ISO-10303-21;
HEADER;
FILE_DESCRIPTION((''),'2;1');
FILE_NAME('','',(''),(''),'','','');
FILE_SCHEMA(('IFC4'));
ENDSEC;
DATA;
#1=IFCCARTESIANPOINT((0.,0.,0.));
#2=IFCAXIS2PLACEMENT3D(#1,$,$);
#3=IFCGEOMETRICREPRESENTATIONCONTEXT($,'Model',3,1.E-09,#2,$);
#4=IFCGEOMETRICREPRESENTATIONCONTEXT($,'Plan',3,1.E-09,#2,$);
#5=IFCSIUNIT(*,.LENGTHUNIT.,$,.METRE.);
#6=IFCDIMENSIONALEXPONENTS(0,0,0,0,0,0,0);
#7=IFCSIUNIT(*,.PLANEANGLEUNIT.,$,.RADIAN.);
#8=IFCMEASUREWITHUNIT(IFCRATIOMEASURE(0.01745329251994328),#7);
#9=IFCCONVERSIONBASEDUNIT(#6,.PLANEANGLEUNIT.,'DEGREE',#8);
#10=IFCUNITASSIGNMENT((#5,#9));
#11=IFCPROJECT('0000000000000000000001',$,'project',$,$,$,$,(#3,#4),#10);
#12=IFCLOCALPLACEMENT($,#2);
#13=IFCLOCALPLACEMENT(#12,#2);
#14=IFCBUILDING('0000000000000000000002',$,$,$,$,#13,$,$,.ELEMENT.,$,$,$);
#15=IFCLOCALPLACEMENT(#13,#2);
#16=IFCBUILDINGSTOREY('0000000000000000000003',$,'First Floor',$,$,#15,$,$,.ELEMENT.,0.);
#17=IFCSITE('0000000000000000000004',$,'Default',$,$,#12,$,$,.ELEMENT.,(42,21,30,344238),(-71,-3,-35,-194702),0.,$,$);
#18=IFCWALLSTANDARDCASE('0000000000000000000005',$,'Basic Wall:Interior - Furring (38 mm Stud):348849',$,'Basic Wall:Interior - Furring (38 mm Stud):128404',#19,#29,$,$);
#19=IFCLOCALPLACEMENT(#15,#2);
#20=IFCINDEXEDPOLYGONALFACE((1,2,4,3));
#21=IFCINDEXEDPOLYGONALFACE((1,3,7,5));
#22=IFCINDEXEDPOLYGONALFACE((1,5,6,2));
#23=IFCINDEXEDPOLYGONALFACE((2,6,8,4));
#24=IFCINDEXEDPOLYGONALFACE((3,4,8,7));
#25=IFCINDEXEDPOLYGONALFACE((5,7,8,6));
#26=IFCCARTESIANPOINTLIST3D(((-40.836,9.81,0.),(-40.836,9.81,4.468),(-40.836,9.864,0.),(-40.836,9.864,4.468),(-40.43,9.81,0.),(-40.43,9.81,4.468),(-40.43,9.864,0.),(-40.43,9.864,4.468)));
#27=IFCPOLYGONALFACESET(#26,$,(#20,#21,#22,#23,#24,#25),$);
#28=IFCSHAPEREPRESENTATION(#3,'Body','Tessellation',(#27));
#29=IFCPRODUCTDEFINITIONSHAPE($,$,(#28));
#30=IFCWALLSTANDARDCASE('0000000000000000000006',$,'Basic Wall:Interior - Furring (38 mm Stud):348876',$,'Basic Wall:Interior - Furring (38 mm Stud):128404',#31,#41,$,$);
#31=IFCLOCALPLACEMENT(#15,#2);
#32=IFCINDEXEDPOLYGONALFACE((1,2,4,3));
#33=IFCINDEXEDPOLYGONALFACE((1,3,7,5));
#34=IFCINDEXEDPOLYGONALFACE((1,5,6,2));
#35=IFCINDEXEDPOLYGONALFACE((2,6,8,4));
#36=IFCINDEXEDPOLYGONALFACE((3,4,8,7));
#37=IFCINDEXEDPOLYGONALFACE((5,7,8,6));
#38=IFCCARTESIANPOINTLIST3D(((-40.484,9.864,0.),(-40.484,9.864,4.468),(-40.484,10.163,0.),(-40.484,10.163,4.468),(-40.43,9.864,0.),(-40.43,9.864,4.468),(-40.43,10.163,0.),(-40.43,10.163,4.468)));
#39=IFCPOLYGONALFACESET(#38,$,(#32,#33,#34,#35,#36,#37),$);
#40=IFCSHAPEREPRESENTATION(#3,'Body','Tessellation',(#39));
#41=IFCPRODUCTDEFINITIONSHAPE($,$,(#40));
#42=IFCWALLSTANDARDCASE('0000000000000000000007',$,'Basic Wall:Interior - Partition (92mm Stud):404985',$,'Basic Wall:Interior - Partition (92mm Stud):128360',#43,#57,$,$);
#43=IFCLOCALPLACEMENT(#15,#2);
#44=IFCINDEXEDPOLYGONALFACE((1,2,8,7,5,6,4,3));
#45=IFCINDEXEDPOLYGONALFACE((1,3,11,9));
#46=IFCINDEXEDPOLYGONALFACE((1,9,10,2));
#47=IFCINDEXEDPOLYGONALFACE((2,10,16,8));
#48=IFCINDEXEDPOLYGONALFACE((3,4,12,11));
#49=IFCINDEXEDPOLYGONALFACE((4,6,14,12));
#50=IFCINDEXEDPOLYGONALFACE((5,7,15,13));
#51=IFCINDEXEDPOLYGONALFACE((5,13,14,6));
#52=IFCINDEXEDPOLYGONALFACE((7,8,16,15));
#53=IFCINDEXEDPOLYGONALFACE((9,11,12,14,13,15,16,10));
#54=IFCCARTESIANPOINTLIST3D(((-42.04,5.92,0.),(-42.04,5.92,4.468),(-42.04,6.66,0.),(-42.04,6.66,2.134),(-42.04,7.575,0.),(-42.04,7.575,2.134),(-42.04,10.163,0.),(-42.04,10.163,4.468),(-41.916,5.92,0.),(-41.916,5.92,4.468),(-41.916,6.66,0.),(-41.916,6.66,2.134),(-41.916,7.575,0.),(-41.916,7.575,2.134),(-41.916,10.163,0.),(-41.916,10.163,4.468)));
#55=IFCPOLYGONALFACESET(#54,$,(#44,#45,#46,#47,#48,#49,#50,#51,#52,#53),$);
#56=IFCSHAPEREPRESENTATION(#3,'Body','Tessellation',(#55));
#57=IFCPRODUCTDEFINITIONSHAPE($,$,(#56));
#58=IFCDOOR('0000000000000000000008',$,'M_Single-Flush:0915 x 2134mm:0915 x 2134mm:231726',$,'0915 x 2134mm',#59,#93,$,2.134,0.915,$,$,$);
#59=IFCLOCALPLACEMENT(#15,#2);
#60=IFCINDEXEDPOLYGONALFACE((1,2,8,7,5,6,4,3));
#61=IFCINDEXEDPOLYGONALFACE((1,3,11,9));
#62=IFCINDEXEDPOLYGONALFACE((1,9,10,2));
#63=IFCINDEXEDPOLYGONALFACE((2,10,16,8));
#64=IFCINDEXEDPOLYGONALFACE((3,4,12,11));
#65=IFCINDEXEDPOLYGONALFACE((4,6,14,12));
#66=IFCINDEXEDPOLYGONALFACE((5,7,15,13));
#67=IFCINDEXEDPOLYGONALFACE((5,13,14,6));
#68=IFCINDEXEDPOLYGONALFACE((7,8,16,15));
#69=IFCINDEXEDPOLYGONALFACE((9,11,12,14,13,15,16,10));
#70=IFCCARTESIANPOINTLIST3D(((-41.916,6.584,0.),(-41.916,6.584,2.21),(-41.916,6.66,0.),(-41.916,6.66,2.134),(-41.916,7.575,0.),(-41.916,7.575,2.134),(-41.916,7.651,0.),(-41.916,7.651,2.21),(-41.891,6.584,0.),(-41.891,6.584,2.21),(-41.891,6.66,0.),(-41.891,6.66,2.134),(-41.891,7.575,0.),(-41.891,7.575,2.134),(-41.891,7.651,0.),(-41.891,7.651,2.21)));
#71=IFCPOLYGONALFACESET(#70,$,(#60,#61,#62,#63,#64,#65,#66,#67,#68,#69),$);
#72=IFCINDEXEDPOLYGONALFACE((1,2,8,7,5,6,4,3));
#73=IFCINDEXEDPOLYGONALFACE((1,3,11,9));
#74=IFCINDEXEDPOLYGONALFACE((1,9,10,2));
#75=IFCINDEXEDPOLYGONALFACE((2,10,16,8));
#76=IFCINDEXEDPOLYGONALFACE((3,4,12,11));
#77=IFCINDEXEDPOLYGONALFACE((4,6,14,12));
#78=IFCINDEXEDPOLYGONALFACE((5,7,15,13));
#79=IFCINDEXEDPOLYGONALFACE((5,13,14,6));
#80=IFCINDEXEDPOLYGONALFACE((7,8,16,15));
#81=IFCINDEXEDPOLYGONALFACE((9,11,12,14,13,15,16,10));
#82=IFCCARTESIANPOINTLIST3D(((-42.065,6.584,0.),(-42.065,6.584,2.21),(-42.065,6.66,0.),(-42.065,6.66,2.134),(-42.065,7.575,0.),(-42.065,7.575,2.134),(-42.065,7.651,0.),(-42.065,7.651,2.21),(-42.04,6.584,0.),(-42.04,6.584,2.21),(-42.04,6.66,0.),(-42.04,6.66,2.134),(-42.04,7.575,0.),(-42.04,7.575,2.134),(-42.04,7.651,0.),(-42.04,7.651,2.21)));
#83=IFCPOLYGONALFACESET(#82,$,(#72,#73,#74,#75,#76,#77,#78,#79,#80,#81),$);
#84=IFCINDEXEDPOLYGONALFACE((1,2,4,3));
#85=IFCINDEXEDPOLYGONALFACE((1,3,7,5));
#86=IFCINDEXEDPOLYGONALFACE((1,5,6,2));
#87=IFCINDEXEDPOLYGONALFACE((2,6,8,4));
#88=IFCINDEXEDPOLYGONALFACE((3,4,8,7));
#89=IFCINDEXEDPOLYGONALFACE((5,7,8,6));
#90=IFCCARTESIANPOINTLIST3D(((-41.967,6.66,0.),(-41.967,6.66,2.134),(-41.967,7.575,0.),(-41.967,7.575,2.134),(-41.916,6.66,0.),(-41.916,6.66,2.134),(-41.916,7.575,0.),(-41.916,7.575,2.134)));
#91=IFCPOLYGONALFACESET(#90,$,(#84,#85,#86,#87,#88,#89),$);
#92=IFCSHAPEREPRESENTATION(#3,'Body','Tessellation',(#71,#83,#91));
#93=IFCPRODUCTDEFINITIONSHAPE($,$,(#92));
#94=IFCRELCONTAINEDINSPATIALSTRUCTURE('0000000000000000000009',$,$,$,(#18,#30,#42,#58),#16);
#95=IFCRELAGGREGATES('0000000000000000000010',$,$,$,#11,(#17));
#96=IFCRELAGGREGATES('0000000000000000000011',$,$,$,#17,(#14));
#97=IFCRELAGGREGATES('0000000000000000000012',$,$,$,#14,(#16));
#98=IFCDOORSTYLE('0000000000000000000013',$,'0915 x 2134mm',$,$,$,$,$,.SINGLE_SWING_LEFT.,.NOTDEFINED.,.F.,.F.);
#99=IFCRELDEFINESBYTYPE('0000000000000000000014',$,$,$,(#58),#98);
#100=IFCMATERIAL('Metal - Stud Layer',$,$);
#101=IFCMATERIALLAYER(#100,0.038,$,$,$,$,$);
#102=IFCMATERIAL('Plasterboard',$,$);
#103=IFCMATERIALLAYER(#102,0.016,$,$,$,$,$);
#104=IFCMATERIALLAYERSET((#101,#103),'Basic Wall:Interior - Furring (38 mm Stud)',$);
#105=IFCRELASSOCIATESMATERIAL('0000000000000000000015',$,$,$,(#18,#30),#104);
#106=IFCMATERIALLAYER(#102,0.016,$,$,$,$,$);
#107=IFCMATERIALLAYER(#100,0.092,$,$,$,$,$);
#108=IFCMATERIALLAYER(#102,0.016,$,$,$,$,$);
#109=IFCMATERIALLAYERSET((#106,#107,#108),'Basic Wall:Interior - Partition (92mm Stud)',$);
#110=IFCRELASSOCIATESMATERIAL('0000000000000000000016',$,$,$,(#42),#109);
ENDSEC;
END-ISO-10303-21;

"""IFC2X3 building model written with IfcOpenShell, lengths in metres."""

from ifc_helpers import new_model, entity, si_unit, converted_unit, frame, frame_2d, origin, origin_2d_with_axis, place, context, project, spatial, polyline, rectangle, outline, extrude, source, transform, mapped, material, layer, layer_set, layer_usage, type_object, type_shapes, element, fill, save


model = new_model("IFC2X3")

# Units and contexts
model_context = context("Model", 3, precision=1e-09, world=origin())
plan_context = context("Plan", 3, precision=1e-09, world=origin())
ifc_project = project(units=[si_unit("LENGTHUNIT", "METRE"), converted_unit("PLANEANGLEUNIT", "DEGREE", entity("IfcRatioMeasure", 0.01745329251994328), si_unit("PLANEANGLEUNIT", "RADIAN"), dimensions=[0, 0, 0, 0, 0, 0, 0])], contexts=[model_context, plan_context])

# Site, building, storey
site_placement = place(None, origin())
site = spatial("IfcSite", under=ifc_project, at=site_placement, Name="Default", CompositionType="ELEMENT", RefLatitude=(42, 21, 30, 344238), RefLongitude=(-71, -3, -35, -194702), RefElevation=0.0)
building_placement = place(site_placement, origin())
building = spatial("IfcBuilding", under=site, at=building_placement, CompositionType="ELEMENT")
storey_placement = place(building_placement, origin())
storey = spatial("IfcBuildingStorey", under=building, at=storey_placement, Name="First Floor", CompositionType="ELEMENT", Elevation=0.0)

# Shared definitions
ifc_material_1 = material(Name="Metal - Stud Layer")
ifc_layer_1 = layer(ifc_material_1, 0.038)
ifc_material_2 = material(Name="Plasterboard")
ifc_layer_2 = layer(ifc_material_2, 0.016)
ifc_layer_set_1 = layer_set([ifc_layer_1, ifc_layer_2], Name="Basic Wall:Interior - Furring (38 mm Stud)")

# Shared definitions
ifc_layer_3 = layer(ifc_material_2, 0.016)
ifc_layer_4 = layer(ifc_material_1, 0.092)
ifc_layer_5 = layer(ifc_material_2, 0.016)
ifc_layer_set_2 = layer_set([ifc_layer_3, ifc_layer_4, ifc_layer_5], Name="Basic Wall:Interior - Partition (92mm Stud)")
door_style_1 = type_object("IfcDoorStyle", Name="0915 x 2134mm", ConstructionType="NOTDEFINED", OperationType="SINGLE_SWING_LEFT", ParameterTakesPrecedence=False, Sizeable=False)
shared_shape_1 = source(origin(), model_context, "Body", "SweptSolid", [
    extrude(outline(polyline([(-0.5335, -1.124), (0.5335, -1.124), (0.5335, 1.086), (0.4575, 1.086), (0.4575, -1.048), (-0.4575, -1.048), (-0.4575, 1.086), (-0.5335, 1.086), (-0.5335, -1.124)])), frame((0.4575, 0.149, 1.086), z_axis=(0.0, -1.0, 0.0), x_axis=(-1.0, 0.0, 0.0)), (0.0, 0.0, 1.0), 0.025),
    extrude(outline(polyline([(-1.124, -0.5335), (1.086, -0.5335), (1.086, -0.4575), (-1.048, -0.4575), (-1.048, 0.4575), (1.086, 0.4575), (1.086, 0.5335), (-1.124, 0.5335), (-1.124, -0.5335)])), frame((0.4575, 0.0, 1.086), z_axis=(0.0, -1.0, 0.0), x_axis=(0.0, 0.0, -1.0)), (0.0, 0.0, 1.0), 0.025),
    extrude(rectangle(XDim=0.915, YDim=0.051, at=origin_2d_with_axis()), frame((0.4575, 0.0985, 0.0)), (0.0, 0.0, 1.0), 2.134),
])
type_shapes(door_style_1, [shared_shape_1])

# Walls
ifc_layer_usage_1 = layer_usage(ifc_layer_set_1, "AXIS2", "NEGATIVE", 0.027)
wall_1_placement = place(storey_placement, frame((-40.836, 9.837, 0.0)))
element("IfcWallStandardCase", 1, at=wall_1_placement, inside=storey, material=ifc_layer_usage_1, Name="Basic Wall:Interior - Furring (38 mm Stud):348849", ObjectType="Basic Wall:Interior - Furring (38 mm Stud):128404", context=model_context, shape_type="SweptSolid", body=[
    extrude(rectangle(XDim=0.406, YDim=0.054, at=frame_2d((0.203, 0.0), x_axis=(-1.0, 0.0))), origin(), (0.0, 0.0, 1.0), 4.468),
])
ifc_layer_usage_2 = layer_usage(ifc_layer_set_1, "AXIS2", "NEGATIVE", 0.027)
wall_2_placement = place(storey_placement, frame((-40.457, 9.864, 0.0), z_axis=(0.0, 0.0, 1.0), x_axis=(0.0, 1.0, 0.0)))
element("IfcWallStandardCase", 2, at=wall_2_placement, inside=storey, material=ifc_layer_usage_2, Name="Basic Wall:Interior - Furring (38 mm Stud):348876", ObjectType="Basic Wall:Interior - Furring (38 mm Stud):128404", context=model_context, shape_type="SweptSolid", body=[
    extrude(rectangle(XDim=0.299, YDim=0.054, at=frame_2d((0.1495, 0.0), x_axis=(-1.0, 0.0))), origin(), (0.0, 0.0, 1.0), 4.468),
])

# Wall, opening, door
ifc_layer_usage_3 = layer_usage(ifc_layer_set_2, "AXIS2", "NEGATIVE", 0.062)
wall_3_placement = place(storey_placement, frame((-41.978, 5.92, 0.0), z_axis=(0.0, 0.0, 1.0), x_axis=(0.0, 1.0, 0.0)))
wall_3 = element("IfcWallStandardCase", 3, at=wall_3_placement, inside=storey, material=ifc_layer_usage_3, Name="Basic Wall:Interior - Partition (92mm Stud):404985", ObjectType="Basic Wall:Interior - Partition (92mm Stud):128360", context=model_context, shape_type="SweptSolid", body=[
    extrude(rectangle(XDim=4.243, YDim=0.124, at=frame_2d((2.1215, 0.0), x_axis=(-1.0, 0.0))), origin(), (0.0, 0.0, 1.0), 4.468),
])
opening_1_placement = place(wall_3_placement, frame((1.655, 0.062, 0.0)))
opening_1 = element("IfcOpeningElement", 4, at=opening_1_placement, cuts=wall_3, ObjectType="Opening", context=model_context, shape_type="SweptSolid", body=[
    extrude(rectangle(XDim=0.915, YDim=2.134, at=frame_2d((1.067, 0.4575), x_axis=(0.0, -1.0))), frame((0.0, 0.0, 0.0), z_axis=(0.0, -1.0, 0.0), x_axis=(0.0, 0.0, 1.0)), (0.0, 0.0, 1.0), 0.124),
])
door_1_placement = place(opening_1_placement, frame((0.0, 0.0, 0.0), z_axis=(0.0, 0.0, 1.0), x_axis=(-1.0, 0.0, 0.0)))
door_1 = element("IfcDoor", 5, at=door_1_placement, inside=storey, type_object=door_style_1, Name="M_Single-Flush:0915 x 2134mm:0915 x 2134mm:231726", ObjectType="0915 x 2134mm", OverallHeight=2.134, OverallWidth=0.915, context=model_context, shape_type="MappedRepresentation", body=[
    mapped(shared_shape_1, transform((0.0, 0.0, 0.0), scale=1.0)),
])
fill(opening_1, door_1)

save(model, "model.ifc")
